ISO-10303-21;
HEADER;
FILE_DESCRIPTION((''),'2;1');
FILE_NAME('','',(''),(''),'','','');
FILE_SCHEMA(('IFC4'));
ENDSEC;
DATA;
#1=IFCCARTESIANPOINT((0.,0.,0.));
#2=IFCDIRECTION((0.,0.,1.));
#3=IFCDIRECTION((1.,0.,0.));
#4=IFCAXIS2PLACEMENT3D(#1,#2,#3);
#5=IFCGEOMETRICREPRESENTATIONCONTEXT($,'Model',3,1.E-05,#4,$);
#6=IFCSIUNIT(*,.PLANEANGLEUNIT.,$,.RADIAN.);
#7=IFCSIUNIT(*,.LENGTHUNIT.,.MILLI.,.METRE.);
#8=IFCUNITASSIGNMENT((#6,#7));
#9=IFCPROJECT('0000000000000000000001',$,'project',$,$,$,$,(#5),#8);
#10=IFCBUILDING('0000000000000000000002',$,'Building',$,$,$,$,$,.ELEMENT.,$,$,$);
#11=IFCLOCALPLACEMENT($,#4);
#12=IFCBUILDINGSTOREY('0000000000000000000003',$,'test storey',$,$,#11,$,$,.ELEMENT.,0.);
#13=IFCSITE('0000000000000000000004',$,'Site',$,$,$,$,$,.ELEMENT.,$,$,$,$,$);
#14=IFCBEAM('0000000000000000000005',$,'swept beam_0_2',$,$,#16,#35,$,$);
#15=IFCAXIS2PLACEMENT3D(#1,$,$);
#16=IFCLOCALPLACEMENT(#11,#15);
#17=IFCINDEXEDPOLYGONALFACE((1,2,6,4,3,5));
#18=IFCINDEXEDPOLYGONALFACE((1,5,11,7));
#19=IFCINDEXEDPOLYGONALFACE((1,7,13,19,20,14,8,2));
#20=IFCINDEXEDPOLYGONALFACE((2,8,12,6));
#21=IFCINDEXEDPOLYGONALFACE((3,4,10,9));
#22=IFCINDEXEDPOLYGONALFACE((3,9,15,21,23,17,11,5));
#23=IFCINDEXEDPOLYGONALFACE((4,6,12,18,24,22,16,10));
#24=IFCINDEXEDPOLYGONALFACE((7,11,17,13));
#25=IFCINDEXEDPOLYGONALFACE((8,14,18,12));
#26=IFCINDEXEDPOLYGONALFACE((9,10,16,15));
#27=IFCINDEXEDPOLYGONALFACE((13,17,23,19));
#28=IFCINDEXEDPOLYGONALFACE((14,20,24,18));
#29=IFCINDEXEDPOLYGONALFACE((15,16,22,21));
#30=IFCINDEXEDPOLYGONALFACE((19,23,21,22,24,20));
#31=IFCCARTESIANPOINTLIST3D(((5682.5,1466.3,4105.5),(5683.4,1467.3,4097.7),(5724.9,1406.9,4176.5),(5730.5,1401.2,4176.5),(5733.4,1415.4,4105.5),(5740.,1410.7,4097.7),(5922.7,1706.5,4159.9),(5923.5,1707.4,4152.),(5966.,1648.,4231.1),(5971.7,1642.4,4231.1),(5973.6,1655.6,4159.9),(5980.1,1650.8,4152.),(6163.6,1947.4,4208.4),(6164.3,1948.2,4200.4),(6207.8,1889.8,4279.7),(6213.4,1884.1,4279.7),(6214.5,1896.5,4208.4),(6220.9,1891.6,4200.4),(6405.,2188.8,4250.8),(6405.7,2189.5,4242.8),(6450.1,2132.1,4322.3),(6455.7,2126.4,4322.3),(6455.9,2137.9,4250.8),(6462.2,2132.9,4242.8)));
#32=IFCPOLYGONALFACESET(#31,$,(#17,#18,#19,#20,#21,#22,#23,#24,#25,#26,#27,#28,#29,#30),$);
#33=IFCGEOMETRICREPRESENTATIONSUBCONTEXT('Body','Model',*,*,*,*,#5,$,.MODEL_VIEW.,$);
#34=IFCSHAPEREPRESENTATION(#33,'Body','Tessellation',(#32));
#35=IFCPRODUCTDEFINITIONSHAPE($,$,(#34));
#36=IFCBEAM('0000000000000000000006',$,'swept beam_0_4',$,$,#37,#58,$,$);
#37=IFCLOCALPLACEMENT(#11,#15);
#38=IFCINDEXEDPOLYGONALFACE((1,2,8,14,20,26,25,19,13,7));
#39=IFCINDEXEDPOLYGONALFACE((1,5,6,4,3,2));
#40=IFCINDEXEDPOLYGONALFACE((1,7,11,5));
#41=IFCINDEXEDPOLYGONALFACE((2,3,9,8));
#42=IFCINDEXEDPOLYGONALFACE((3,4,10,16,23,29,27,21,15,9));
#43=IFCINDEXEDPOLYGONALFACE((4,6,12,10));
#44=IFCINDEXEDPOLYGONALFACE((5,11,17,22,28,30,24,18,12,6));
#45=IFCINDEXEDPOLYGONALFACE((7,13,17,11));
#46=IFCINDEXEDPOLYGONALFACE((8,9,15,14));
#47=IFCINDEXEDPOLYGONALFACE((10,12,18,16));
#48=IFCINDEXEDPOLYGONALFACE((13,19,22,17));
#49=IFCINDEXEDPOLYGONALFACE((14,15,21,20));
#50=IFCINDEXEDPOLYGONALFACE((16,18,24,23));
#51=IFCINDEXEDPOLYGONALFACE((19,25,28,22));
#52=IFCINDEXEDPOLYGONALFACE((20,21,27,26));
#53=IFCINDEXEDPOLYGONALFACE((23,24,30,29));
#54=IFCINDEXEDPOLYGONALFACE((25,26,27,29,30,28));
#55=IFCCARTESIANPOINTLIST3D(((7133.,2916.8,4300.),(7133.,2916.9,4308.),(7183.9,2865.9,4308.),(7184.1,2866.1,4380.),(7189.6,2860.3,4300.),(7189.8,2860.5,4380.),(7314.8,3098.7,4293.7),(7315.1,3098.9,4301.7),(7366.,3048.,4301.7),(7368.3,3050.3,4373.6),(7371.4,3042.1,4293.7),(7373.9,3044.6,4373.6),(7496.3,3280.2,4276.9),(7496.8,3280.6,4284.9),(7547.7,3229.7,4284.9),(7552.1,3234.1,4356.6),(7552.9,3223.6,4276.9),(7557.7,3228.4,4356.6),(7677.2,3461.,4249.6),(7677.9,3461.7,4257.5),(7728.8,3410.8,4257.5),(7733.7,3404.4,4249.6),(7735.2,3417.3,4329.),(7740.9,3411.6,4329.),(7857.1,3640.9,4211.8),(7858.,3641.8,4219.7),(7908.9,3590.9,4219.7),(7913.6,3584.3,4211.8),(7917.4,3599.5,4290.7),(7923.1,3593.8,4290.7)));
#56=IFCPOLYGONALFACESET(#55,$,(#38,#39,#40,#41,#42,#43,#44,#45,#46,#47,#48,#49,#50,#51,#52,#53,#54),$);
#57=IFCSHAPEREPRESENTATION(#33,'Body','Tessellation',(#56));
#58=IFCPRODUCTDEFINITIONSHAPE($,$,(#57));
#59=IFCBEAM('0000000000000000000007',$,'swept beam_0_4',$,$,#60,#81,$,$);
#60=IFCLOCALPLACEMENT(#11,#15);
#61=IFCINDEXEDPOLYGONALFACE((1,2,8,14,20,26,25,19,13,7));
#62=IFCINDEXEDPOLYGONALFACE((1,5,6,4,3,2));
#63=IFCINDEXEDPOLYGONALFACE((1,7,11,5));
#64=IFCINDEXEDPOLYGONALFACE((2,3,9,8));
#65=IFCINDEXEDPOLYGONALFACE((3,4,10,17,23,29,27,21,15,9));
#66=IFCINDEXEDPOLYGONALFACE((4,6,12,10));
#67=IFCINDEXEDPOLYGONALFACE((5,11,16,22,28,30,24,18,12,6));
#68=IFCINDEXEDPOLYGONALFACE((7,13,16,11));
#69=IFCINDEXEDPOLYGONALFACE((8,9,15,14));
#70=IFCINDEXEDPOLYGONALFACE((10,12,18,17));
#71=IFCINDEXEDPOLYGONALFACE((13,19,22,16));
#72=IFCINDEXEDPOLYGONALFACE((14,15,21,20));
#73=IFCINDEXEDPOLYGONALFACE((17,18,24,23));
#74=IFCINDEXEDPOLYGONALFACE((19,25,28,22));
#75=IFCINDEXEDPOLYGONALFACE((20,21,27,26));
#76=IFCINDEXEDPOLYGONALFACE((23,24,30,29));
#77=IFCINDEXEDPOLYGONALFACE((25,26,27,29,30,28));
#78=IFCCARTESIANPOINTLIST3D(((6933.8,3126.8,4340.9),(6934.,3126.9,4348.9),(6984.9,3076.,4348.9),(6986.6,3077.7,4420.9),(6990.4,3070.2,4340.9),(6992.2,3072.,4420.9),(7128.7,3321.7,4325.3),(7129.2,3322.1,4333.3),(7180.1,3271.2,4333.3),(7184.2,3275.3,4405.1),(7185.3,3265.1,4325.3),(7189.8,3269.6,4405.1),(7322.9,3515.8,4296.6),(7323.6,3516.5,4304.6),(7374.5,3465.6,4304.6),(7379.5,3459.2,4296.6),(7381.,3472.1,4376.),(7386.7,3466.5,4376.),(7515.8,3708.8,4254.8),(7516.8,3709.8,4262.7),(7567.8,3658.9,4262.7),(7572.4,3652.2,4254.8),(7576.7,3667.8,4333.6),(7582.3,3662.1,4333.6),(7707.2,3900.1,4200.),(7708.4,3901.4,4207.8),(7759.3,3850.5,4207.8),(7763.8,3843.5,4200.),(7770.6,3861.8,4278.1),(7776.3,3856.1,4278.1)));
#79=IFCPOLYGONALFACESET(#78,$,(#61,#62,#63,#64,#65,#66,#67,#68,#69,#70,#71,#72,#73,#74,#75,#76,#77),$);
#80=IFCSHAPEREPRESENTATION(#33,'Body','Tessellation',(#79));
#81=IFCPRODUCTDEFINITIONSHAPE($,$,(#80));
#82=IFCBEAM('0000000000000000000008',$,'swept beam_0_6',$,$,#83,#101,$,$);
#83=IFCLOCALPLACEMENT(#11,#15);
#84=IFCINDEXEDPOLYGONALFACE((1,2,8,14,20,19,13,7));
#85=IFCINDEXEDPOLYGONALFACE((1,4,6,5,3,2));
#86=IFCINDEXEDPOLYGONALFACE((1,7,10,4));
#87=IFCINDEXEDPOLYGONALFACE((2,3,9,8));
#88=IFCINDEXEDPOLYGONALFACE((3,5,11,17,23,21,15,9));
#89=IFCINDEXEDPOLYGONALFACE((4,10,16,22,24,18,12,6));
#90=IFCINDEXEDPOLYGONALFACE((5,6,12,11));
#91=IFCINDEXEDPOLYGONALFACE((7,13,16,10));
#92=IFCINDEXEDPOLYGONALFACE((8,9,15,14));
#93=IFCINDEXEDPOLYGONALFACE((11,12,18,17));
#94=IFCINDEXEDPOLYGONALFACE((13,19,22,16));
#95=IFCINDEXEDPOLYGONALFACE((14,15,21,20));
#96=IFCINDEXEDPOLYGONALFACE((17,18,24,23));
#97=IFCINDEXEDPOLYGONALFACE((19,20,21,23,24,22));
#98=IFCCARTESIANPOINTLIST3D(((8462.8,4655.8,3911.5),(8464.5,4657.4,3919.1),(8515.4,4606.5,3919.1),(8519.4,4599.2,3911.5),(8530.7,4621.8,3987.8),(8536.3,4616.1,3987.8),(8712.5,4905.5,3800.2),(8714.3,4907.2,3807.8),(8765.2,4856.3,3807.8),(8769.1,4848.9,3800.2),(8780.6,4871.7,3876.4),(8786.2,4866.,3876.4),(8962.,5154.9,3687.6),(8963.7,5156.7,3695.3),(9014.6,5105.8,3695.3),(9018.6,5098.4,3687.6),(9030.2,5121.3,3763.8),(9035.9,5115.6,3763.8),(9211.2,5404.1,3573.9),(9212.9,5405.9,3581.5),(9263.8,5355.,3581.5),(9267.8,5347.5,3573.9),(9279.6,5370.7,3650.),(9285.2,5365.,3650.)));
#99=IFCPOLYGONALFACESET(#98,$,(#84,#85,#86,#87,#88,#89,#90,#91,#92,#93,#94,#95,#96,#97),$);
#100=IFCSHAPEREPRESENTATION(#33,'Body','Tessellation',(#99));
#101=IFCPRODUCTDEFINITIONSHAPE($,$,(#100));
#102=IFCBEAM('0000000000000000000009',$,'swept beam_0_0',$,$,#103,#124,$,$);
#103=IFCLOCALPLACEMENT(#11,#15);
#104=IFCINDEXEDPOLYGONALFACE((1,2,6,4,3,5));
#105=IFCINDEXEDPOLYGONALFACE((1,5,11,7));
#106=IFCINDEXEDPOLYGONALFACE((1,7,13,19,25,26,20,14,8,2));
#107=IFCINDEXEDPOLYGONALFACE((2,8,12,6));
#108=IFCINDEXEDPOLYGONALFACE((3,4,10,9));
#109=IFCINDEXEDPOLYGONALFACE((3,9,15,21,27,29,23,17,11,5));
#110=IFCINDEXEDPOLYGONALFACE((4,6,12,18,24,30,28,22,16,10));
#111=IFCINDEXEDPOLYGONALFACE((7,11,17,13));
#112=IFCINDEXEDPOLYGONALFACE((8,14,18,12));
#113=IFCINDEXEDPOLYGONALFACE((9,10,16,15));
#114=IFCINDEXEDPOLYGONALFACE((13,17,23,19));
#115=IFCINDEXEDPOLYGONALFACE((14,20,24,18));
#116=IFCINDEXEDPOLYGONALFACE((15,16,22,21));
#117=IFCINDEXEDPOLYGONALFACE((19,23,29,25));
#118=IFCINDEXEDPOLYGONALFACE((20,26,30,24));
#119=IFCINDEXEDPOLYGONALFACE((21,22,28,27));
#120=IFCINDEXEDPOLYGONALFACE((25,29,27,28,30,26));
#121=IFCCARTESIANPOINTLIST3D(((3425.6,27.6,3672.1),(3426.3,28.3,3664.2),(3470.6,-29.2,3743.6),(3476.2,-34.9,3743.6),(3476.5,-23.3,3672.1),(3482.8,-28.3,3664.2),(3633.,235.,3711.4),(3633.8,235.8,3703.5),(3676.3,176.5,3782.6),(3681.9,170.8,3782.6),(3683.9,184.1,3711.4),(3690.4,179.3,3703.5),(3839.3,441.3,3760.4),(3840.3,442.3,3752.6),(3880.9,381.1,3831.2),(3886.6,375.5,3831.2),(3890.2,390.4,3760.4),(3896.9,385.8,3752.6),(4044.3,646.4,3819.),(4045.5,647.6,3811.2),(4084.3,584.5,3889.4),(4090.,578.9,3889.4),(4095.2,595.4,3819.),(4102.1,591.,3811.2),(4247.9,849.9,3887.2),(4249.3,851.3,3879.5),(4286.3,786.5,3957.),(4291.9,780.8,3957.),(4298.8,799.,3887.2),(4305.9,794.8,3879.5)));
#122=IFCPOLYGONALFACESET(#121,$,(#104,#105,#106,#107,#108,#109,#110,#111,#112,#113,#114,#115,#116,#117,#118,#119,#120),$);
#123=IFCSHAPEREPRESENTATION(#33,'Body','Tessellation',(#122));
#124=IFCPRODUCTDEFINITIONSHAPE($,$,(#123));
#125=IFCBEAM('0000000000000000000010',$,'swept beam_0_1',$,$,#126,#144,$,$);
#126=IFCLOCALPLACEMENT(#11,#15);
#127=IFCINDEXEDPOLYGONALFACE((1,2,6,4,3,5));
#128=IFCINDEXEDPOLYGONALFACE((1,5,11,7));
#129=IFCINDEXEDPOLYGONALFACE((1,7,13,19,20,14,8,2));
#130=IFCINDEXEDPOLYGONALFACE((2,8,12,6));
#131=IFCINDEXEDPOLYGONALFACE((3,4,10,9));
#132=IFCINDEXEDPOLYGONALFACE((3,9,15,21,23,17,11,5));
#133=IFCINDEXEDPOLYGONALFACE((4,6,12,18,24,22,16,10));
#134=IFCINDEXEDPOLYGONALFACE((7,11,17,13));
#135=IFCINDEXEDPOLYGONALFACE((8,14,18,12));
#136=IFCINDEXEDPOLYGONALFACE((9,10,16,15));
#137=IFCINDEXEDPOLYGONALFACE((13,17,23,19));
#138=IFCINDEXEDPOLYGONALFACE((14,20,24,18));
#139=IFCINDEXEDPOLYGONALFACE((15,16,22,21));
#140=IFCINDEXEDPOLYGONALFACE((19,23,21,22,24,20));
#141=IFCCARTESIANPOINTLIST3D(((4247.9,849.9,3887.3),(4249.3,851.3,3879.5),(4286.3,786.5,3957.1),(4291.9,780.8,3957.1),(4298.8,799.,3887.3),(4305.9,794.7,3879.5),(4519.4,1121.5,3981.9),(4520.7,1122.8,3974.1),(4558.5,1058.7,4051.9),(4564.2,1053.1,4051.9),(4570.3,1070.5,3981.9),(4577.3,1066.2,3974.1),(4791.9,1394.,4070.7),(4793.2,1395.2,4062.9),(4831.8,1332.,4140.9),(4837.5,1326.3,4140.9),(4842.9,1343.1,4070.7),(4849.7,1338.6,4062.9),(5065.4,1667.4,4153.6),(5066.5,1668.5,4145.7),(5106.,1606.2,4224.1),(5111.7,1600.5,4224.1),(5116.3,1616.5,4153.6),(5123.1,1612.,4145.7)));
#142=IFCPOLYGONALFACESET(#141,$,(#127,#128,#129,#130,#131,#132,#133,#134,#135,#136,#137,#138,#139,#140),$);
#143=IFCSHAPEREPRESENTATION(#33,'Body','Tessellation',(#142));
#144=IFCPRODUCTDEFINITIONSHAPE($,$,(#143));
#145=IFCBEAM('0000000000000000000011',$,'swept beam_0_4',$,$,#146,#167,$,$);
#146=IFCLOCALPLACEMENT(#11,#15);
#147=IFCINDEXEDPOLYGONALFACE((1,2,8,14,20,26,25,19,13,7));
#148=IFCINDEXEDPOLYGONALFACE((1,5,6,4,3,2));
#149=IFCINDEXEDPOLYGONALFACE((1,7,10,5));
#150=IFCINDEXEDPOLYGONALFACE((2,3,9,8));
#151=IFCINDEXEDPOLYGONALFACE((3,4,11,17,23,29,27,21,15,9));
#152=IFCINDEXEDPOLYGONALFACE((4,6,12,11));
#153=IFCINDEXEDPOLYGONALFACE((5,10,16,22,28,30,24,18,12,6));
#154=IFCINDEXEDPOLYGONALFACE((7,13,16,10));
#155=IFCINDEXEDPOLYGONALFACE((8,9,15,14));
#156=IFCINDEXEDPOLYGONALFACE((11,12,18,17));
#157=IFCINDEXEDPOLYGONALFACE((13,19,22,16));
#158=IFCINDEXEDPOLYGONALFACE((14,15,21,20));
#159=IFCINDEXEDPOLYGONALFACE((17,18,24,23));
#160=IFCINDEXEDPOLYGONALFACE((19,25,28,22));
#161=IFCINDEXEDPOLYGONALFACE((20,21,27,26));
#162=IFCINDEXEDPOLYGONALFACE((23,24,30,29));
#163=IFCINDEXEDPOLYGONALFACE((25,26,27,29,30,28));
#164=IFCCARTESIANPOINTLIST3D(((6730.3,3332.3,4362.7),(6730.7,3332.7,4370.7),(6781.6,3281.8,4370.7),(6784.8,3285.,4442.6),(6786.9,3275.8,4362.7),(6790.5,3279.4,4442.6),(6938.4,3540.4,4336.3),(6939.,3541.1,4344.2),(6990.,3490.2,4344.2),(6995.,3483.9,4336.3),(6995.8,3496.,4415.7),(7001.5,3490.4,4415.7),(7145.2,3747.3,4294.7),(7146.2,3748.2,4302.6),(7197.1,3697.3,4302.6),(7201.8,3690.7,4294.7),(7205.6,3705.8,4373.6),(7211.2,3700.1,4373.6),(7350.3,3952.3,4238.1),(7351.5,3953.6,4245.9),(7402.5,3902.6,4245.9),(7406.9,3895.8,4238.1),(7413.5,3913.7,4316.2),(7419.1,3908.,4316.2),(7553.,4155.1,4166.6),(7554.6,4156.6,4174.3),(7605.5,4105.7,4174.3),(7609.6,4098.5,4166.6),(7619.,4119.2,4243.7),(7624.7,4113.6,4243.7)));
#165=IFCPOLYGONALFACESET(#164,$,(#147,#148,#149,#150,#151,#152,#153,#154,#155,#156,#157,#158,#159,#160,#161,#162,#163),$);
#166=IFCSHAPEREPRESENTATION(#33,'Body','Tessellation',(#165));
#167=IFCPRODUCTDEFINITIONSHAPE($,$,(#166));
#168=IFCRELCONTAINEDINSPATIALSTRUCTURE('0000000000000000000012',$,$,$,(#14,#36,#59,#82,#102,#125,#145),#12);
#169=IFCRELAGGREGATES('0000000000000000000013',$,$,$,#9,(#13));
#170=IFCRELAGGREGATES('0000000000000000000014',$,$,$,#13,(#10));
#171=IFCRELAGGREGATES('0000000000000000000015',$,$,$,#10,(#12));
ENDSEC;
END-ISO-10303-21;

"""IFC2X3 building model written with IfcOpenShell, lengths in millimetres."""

from ifc_helpers import new_model, entity, si_unit, origin_with_axes, place, context, subcontext, project, spatial, element, save


model = new_model("IFC2X3")

# Units and contexts
model_context = context("Model", 3, precision=1e-05, world=origin_with_axes())
body_context = subcontext(model_context, "Body", "Model", "MODEL_VIEW")
ifc_project = project(units=[si_unit("PLANEANGLEUNIT", "RADIAN"), si_unit("LENGTHUNIT", "METRE", prefix="MILLI")], contexts=[model_context])

# Site, building, storey
site = spatial("IfcSite", under=ifc_project, Name="Site", CompositionType="ELEMENT")
building = spatial("IfcBuilding", under=site, Name="Building", CompositionType="ELEMENT")
storey_placement = place(None, origin_with_axes())
storey = spatial("IfcBuildingStorey", under=building, at=storey_placement, Name="test storey", CompositionType="ELEMENT", Elevation=0.0)

# Beams
beam_1_placement = place(storey_placement, origin_with_axes())
element("IfcBeam", 1, at=beam_1_placement, inside=storey, Name="swept beam_0_2", context=body_context, shape_type="SweptSolid", body=[
    entity("IfcRevolvedAreaSolid", entity("IfcArbitraryClosedProfileDef", "AREA", None, entity("IfcPolyline", [entity("IfcCartesianPoint", [80.0, -40.0]), entity("IfcCartesianPoint", [80.0, -32.0]), entity("IfcCartesianPoint", [8.0, -32.0]), entity("IfcCartesianPoint", [8.0, 40.0]), entity("IfcCartesianPoint", [0.0, 40.0]), entity("IfcCartesianPoint", [0.0, -40.0]), entity("IfcCartesianPoint", [80.0, -40.0])])), entity("IfcAxis2Placement3D", entity("IfcCartesianPoint", [5711.7, 1439.0, 4097.7]), entity("IfcDirection", [-0.6972, -0.6972, -0.1668]), entity("IfcDirection", [-0.118, -0.118, 0.986])), entity("IfcAxis1Placement", entity("IfcCartesianPoint", [-19536.1, 0.0, 0.0]), entity("IfcDirection", [0.0, 1.0, 0.0])), 0.052814),
])
beam_2_placement = place(storey_placement, origin_with_axes())
element("IfcBeam", 2, at=beam_2_placement, inside=storey, Name="swept beam_0_4", context=body_context, shape_type="SweptSolid", body=[
    entity("IfcRevolvedAreaSolid", entity("IfcArbitraryClosedProfileDef", "AREA", None, entity("IfcPolyline", [entity("IfcCartesianPoint", [80.0, -40.0]), entity("IfcCartesianPoint", [80.0, -32.0]), entity("IfcCartesianPoint", [8.0, -32.0]), entity("IfcCartesianPoint", [8.0, 40.0]), entity("IfcCartesianPoint", [0.0, 40.0]), entity("IfcCartesianPoint", [0.0, -40.0]), entity("IfcCartesianPoint", [80.0, -40.0])])), entity("IfcAxis2Placement3D", entity("IfcCartesianPoint", [7161.3, 2888.6, 4300.0]), entity("IfcDirection", [-0.7071, -0.7071, 0.0038]), entity("IfcDirection", [0.0027, 0.0027, 1.0])), entity("IfcAxis1Placement", entity("IfcCartesianPoint", [-6265.3, 0.0, 0.0]), entity("IfcDirection", [0.0, 1.0, 0.0])), 0.164227),
])
beam_3_placement = place(storey_placement, origin_with_axes())
element("IfcBeam", 3, at=beam_3_placement, inside=storey, Name="swept beam_0_4", context=body_context, shape_type="SweptSolid", body=[
    entity("IfcRevolvedAreaSolid", entity("IfcArbitraryClosedProfileDef", "AREA", None, entity("IfcPolyline", [entity("IfcCartesianPoint", [80.0, -40.0]), entity("IfcCartesianPoint", [80.0, -32.0]), entity("IfcCartesianPoint", [8.0, -32.0]), entity("IfcCartesianPoint", [8.0, 40.0]), entity("IfcCartesianPoint", [0.0, 40.0]), entity("IfcCartesianPoint", [0.0, -40.0]), entity("IfcCartesianPoint", [80.0, -40.0])])), entity("IfcAxis2Placement3D", entity("IfcCartesianPoint", [6962.1, 3098.5, 4340.9]), entity("IfcDirection", [-0.7067, -0.7067, 0.0325]), entity("IfcDirection", [0.023, 0.023, 0.9995])), entity("IfcAxis1Placement", entity("IfcCartesianPoint", [-5777.5, 0.0, 0.0]), entity("IfcDirection", [0.0, 1.0, 0.0])), 0.191159),
])
beam_4_placement = place(storey_placement, origin_with_axes())
element("IfcBeam", 4, at=beam_4_placement, inside=storey, Name="swept beam_0_6", context=body_context, shape_type="SweptSolid", body=[
    entity("IfcRevolvedAreaSolid", entity("IfcArbitraryClosedProfileDef", "AREA", None, entity("IfcPolyline", [entity("IfcCartesianPoint", [80.0, -40.0]), entity("IfcCartesianPoint", [80.0, -32.0]), entity("IfcCartesianPoint", [8.0, -32.0]), entity("IfcCartesianPoint", [8.0, 40.0]), entity("IfcCartesianPoint", [0.0, 40.0]), entity("IfcCartesianPoint", [0.0, -40.0]), entity("IfcCartesianPoint", [80.0, -40.0])])), entity("IfcAxis2Placement3D", entity("IfcCartesianPoint", [8491.1, 4627.5, 3911.5]), entity("IfcDirection", [-0.6747, -0.6747, 0.299]), entity("IfcDirection", [0.2115, 0.2115, 0.9542])), entity("IfcAxis1Placement", entity("IfcCartesianPoint", [-108820.3, 0.0, 0.0]), entity("IfcDirection", [0.0, 1.0, 0.0])), 0.010208),
])
beam_5_placement = place(storey_placement, origin_with_axes())
element("IfcBeam", 5, at=beam_5_placement, inside=storey, Name="swept beam_0_0", context=body_context, shape_type="SweptSolid", body=[
    entity("IfcRevolvedAreaSolid", entity("IfcArbitraryClosedProfileDef", "AREA", None, entity("IfcPolyline", [entity("IfcCartesianPoint", [-80.0, 40.0]), entity("IfcCartesianPoint", [-80.0, 32.0]), entity("IfcCartesianPoint", [-8.0, 32.0]), entity("IfcCartesianPoint", [-8.0, -40.0]), entity("IfcCartesianPoint", [0.0, -40.0]), entity("IfcCartesianPoint", [0.0, 40.0]), entity("IfcCartesianPoint", [-80.0, 40.0])])), entity("IfcAxis2Placement3D", entity("IfcCartesianPoint", [3454.5, 0.0, 3664.2]), entity("IfcDirection", [-0.7023, -0.7023, -0.1165]), entity("IfcDirection", [0.0824, 0.0824, -0.9932])), entity("IfcAxis1Placement", entity("IfcCartesianPoint", [-8951.7, 0.0, 0.0]), entity("IfcDirection", [0.0, 1.0, 0.0])), 0.132328),
])
beam_6_placement = place(storey_placement, origin_with_axes())
element("IfcBeam", 6, at=beam_6_placement, inside=storey, Name="swept beam_0_1", context=body_context, shape_type="SweptSolid", body=[
    entity("IfcRevolvedAreaSolid", entity("IfcArbitraryClosedProfileDef", "AREA", None, entity("IfcPolyline", [entity("IfcCartesianPoint", [80.0, -40.0]), entity("IfcCartesianPoint", [80.0, -32.0]), entity("IfcCartesianPoint", [8.0, -32.0]), entity("IfcCartesianPoint", [8.0, 40.0]), entity("IfcCartesianPoint", [0.0, 40.0]), entity("IfcCartesianPoint", [0.0, -40.0]), entity("IfcCartesianPoint", [80.0, -40.0])])), entity("IfcAxis2Placement3D", entity("IfcCartesianPoint", [4277.6, 823.0, 3879.5]), entity("IfcDirection", [-0.6853, -0.6853, -0.2466]), entity("IfcDirection", [-0.1744, -0.1744, 0.9691])), entity("IfcAxis1Placement", entity("IfcCartesianPoint", [-26038.3, 0.0, 0.0]), entity("IfcDirection", [0.0, 1.0, 0.0])), 0.045552),
])
beam_7_placement = place(storey_placement, origin_with_axes())
element("IfcBeam", 7, at=beam_7_placement, inside=storey, Name="swept beam_0_4", context=body_context, shape_type="SweptSolid", body=[
    entity("IfcRevolvedAreaSolid", entity("IfcArbitraryClosedProfileDef", "AREA", None, entity("IfcPolyline", [entity("IfcCartesianPoint", [80.0, -40.0]), entity("IfcCartesianPoint", [80.0, -32.0]), entity("IfcCartesianPoint", [8.0, -32.0]), entity("IfcCartesianPoint", [8.0, 40.0]), entity("IfcCartesianPoint", [0.0, 40.0]), entity("IfcCartesianPoint", [0.0, -40.0]), entity("IfcCartesianPoint", [80.0, -40.0])])), entity("IfcAxis2Placement3D", entity("IfcCartesianPoint", [6758.6, 3304.0, 4362.7]), entity("IfcDirection", [-0.7057, -0.7057, 0.0639]), entity("IfcDirection", [0.0452, 0.0452, 0.998])), entity("IfcAxis1Placement", entity("IfcCartesianPoint", [-5733.8, 0.0, 0.0]), entity("IfcDirection", [0.0, 1.0, 0.0])), 0.206153),
])

save(model, "model.ifc")
